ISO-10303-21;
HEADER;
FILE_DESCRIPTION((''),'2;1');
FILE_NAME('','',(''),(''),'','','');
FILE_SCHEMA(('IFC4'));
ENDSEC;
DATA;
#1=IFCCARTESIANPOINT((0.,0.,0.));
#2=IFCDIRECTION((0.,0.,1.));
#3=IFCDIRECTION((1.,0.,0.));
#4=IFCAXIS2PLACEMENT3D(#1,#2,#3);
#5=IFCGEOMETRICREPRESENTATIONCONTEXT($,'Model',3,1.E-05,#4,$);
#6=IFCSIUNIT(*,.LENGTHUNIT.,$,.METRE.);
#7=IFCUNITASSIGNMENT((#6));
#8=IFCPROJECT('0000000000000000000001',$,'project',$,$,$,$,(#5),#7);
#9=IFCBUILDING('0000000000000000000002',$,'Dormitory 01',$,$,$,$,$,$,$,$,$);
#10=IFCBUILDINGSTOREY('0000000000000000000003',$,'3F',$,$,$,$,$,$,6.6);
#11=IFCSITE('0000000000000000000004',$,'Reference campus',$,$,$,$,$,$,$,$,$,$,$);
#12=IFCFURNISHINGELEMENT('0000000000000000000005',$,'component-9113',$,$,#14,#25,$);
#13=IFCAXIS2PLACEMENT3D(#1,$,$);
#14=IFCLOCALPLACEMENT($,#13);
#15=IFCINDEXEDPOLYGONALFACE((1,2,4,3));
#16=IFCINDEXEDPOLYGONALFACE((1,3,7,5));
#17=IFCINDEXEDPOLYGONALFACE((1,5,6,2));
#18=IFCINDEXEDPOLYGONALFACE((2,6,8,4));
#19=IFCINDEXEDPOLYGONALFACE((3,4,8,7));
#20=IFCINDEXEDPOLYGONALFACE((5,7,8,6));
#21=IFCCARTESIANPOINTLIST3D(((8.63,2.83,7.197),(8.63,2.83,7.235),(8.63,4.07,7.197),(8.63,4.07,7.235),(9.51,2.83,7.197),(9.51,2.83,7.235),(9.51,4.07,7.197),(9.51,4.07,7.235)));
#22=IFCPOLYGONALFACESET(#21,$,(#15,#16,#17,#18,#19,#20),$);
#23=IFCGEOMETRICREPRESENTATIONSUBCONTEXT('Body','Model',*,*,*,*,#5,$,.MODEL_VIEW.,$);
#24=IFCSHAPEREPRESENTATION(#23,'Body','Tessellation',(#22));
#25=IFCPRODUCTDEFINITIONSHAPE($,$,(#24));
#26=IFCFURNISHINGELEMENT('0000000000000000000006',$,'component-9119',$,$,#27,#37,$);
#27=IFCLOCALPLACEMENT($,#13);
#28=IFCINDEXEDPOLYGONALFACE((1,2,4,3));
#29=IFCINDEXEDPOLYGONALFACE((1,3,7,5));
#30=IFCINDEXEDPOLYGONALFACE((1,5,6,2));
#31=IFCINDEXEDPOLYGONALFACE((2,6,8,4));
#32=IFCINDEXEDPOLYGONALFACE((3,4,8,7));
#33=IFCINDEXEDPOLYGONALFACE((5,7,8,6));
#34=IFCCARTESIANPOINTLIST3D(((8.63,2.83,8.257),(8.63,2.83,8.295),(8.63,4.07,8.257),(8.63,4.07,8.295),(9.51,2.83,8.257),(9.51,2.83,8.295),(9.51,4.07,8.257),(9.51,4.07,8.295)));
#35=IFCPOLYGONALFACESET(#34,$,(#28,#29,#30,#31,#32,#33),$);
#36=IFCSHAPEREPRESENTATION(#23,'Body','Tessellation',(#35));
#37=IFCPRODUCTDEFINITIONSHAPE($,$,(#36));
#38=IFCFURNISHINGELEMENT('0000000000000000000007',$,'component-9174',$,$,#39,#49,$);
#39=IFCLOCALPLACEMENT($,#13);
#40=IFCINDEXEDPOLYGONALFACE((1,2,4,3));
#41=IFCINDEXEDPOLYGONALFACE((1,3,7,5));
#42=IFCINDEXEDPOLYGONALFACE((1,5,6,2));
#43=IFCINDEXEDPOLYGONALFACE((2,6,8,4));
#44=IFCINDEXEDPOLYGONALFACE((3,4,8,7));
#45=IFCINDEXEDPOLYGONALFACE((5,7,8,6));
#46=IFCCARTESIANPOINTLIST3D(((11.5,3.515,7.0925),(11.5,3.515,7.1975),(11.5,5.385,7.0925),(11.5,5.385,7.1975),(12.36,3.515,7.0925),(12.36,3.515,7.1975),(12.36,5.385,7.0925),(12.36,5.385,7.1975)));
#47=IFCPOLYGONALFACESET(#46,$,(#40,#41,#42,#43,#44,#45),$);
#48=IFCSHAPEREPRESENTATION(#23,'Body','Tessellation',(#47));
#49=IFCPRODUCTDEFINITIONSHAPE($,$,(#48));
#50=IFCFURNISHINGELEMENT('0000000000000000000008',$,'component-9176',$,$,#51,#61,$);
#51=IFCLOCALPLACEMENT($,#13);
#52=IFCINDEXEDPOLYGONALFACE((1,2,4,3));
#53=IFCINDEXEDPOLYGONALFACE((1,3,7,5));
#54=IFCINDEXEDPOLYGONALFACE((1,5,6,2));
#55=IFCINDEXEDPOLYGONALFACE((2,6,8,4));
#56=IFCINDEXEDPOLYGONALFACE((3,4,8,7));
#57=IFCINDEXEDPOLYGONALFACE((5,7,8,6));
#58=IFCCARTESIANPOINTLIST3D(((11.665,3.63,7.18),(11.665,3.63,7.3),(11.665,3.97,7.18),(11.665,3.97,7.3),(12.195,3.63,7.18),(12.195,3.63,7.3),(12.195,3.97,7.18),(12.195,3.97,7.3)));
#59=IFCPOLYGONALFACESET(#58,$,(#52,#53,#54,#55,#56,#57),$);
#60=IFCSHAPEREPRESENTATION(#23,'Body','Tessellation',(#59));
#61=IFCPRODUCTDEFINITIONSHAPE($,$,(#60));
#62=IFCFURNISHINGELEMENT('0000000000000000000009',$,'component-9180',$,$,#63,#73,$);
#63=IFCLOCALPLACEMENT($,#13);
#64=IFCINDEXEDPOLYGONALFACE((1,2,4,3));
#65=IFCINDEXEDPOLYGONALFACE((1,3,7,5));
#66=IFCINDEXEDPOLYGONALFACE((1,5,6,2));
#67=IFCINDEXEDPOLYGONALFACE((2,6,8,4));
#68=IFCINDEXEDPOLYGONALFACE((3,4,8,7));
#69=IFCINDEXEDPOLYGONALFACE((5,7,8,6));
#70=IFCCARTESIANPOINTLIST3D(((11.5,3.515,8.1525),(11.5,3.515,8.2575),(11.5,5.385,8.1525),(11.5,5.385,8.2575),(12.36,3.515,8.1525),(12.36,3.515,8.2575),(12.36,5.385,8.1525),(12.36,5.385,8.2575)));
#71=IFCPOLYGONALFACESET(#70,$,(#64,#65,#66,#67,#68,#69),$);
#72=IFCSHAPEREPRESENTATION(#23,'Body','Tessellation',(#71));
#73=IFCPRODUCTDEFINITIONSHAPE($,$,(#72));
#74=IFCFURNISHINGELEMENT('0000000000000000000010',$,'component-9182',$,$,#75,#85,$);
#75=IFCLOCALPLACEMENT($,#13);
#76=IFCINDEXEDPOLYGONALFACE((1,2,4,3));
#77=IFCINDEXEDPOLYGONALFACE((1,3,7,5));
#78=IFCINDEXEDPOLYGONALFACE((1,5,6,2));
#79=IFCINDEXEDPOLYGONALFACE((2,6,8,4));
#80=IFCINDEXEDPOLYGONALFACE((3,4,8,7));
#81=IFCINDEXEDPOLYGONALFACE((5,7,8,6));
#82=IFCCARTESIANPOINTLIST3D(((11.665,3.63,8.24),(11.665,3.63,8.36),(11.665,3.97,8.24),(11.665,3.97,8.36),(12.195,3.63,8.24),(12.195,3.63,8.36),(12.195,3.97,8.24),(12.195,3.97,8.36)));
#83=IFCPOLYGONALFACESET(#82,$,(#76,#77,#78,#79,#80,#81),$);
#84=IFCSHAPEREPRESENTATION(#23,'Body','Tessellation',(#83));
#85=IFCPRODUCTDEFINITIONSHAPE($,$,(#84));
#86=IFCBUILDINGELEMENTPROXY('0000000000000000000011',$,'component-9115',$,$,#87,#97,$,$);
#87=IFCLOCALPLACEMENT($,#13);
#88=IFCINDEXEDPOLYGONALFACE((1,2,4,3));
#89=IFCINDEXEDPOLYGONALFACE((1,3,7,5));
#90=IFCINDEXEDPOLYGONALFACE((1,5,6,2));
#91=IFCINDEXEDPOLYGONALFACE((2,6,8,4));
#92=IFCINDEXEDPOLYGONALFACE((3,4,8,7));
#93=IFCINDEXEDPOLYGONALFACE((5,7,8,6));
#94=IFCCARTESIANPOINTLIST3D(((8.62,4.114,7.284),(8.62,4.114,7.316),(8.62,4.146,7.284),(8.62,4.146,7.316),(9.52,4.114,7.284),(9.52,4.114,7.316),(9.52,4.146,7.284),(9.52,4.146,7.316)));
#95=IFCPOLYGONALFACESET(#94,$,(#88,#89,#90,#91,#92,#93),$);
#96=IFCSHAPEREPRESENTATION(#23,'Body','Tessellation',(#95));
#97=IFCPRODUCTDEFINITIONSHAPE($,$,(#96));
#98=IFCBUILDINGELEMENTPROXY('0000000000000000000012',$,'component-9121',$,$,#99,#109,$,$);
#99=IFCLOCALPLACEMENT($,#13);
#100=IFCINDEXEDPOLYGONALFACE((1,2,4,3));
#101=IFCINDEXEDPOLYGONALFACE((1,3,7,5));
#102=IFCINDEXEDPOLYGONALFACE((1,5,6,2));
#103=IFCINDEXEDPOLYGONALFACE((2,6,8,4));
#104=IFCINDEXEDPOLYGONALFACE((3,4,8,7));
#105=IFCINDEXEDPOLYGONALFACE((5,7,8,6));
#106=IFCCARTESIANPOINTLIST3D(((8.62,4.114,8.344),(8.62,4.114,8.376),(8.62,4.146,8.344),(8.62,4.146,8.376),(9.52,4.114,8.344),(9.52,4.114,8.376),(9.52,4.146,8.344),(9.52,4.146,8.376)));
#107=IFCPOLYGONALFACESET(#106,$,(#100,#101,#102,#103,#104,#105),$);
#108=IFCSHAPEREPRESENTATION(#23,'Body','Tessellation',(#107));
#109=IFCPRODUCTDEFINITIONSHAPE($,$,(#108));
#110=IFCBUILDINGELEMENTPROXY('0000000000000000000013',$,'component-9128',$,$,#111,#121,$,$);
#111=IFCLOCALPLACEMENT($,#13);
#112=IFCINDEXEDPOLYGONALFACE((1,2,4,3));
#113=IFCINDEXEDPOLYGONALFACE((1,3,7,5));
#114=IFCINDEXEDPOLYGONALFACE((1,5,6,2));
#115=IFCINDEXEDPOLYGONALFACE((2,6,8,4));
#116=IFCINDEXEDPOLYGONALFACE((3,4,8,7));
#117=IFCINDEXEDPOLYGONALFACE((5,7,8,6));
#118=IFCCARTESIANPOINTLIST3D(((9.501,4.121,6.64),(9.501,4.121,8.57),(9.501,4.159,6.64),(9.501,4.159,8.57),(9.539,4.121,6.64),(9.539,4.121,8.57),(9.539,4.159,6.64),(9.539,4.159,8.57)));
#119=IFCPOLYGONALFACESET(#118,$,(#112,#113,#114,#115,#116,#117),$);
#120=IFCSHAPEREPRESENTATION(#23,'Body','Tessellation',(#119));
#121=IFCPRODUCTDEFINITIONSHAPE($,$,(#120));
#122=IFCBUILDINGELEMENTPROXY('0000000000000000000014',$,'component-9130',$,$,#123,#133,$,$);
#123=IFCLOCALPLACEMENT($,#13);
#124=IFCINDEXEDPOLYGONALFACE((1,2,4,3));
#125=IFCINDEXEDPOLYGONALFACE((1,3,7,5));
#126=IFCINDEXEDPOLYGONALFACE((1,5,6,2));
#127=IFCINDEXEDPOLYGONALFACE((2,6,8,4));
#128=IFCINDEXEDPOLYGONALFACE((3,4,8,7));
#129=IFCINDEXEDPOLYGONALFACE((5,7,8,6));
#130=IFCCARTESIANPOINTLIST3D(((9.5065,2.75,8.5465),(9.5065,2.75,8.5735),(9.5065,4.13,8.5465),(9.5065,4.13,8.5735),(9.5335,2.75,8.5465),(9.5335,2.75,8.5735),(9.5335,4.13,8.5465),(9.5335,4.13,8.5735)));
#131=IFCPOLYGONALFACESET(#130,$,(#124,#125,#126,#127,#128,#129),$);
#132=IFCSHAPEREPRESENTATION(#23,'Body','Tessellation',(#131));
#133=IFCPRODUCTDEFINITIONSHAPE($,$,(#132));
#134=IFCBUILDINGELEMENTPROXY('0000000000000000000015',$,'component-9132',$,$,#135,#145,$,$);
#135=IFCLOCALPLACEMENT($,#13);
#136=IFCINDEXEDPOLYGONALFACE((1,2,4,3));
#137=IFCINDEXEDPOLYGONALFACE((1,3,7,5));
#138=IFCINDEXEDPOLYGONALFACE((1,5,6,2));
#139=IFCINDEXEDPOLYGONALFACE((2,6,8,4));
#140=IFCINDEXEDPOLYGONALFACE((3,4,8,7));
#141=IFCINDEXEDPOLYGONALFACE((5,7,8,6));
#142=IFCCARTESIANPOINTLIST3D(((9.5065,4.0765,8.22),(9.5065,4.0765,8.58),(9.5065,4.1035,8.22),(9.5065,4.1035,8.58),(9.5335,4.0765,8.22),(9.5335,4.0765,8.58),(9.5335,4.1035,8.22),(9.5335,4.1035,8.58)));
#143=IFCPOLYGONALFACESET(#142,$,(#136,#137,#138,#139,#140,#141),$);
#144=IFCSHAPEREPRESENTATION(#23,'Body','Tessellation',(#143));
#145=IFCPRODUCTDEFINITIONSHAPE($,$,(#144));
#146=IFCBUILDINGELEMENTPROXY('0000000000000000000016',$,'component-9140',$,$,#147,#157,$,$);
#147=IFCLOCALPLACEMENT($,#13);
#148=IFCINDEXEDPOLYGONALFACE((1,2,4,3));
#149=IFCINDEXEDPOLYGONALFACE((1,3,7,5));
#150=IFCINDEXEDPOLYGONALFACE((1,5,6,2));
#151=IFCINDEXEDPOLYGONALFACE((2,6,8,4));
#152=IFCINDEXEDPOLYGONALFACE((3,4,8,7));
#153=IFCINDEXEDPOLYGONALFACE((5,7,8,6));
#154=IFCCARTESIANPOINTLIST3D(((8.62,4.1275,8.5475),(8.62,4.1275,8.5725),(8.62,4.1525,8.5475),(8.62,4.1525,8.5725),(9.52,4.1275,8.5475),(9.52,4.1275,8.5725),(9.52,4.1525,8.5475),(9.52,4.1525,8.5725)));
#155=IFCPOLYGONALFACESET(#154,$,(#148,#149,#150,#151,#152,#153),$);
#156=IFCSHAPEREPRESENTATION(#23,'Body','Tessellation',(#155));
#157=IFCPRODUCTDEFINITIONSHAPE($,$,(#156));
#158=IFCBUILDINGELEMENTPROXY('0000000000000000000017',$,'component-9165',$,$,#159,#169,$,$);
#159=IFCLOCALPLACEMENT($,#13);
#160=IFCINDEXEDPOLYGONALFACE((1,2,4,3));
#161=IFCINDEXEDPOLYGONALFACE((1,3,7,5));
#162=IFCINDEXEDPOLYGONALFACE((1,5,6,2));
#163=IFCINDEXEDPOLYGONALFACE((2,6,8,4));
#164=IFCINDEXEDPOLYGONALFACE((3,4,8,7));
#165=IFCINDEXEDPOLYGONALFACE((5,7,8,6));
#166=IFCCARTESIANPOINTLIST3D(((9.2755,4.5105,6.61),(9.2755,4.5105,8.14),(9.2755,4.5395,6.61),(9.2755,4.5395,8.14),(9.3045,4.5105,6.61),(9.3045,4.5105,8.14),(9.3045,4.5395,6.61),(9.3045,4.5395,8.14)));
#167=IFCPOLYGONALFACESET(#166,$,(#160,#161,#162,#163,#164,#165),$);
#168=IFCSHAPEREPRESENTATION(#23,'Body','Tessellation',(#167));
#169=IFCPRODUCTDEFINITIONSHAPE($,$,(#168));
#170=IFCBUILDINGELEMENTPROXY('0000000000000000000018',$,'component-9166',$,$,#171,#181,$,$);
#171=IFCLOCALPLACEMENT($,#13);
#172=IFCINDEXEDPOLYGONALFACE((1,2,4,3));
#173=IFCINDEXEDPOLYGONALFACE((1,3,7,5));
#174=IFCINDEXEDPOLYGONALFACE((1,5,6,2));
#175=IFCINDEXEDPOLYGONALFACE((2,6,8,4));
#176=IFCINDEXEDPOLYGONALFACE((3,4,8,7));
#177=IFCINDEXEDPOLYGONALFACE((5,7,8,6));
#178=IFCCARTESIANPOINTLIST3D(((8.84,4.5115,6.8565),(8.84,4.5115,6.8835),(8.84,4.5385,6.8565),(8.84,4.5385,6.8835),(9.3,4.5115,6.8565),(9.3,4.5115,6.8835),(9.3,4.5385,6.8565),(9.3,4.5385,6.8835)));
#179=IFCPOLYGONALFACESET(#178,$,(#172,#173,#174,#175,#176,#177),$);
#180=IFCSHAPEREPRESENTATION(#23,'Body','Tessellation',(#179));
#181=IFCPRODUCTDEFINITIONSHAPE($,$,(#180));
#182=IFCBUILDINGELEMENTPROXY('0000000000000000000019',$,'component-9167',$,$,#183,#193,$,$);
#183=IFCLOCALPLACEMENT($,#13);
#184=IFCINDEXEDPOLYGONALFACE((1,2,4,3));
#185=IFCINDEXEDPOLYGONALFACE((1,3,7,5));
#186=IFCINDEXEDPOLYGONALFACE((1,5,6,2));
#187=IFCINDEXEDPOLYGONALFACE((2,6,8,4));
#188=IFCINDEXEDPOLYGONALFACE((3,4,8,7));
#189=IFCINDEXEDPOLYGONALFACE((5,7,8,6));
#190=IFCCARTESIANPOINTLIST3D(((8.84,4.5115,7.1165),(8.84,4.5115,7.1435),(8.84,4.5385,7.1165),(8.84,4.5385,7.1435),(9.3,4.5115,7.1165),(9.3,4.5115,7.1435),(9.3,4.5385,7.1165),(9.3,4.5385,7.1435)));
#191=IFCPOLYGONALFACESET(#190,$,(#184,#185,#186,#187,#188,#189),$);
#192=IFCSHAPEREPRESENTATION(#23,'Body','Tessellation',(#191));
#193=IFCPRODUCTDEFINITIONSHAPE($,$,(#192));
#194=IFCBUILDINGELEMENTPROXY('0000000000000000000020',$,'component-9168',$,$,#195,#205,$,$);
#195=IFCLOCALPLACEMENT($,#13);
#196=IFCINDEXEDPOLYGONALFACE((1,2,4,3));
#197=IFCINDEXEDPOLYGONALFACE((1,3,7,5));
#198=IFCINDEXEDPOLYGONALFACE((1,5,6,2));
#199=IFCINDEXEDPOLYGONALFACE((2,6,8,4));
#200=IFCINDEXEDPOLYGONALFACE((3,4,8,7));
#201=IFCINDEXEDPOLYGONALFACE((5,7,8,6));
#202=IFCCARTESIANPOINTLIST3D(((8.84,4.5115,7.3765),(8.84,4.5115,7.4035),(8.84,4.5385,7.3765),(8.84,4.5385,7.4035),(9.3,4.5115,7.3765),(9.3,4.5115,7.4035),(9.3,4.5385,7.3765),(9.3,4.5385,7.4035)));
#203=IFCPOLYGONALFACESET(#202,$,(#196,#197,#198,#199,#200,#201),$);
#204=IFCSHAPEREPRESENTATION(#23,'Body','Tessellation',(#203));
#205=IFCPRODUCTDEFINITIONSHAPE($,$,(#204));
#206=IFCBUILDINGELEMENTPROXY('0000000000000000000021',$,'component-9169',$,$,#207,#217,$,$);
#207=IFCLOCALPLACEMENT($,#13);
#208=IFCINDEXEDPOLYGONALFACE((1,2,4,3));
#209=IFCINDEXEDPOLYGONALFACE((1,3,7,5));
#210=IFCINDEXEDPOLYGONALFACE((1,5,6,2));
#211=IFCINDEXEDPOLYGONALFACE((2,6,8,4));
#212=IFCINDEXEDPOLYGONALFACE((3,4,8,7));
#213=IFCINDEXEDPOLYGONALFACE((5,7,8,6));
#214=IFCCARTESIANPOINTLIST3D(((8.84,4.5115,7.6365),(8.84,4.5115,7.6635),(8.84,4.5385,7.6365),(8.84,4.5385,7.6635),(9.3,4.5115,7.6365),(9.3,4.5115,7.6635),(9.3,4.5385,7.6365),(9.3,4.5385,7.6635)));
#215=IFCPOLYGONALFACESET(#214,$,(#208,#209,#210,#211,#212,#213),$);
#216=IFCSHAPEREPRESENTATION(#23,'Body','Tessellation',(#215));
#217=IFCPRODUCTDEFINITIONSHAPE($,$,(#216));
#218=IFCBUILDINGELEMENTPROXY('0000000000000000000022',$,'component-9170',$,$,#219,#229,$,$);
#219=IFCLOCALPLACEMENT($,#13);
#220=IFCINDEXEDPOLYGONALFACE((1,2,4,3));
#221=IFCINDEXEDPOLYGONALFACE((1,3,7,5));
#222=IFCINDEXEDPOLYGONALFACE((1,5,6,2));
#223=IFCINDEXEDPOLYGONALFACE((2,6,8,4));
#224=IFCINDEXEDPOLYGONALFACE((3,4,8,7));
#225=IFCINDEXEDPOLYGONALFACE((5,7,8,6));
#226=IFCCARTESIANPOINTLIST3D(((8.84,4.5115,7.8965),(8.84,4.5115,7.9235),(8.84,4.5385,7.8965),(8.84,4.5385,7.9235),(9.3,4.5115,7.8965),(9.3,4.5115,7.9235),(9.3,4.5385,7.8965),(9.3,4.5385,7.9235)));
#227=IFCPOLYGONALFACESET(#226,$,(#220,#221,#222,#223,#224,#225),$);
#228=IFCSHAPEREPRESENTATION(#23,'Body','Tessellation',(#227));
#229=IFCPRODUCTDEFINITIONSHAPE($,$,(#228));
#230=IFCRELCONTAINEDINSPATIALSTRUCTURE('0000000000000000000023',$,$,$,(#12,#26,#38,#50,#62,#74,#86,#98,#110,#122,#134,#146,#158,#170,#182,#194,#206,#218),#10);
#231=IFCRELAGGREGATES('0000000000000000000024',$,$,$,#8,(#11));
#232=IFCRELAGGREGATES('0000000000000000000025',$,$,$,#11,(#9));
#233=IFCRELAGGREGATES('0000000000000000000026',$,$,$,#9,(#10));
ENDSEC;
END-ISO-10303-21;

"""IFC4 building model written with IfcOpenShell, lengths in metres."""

from ifc_helpers import new_model, si_unit, frame, origin, origin_with_axes, origin_2d, place, context, subcontext, project, spatial, rectangle, extrude, element, save


model = new_model("IFC4")

# Units and contexts
model_context = context("Model", 3, precision=1e-05, world=origin_with_axes())
body_context = subcontext(model_context, "Body", "Model", "MODEL_VIEW")
ifc_project = project(units=[si_unit("LENGTHUNIT", "METRE")], contexts=[model_context])

# Site, building, storey
site = spatial("IfcSite", under=ifc_project, Name="Reference campus")
building = spatial("IfcBuilding", under=site, Name="Dormitory 01")
storey = spatial("IfcBuildingStorey", under=building, Name="3F", Elevation=6.6)

# Furnishing elements
for number, where, z_axis, x_axis, name in (
    (1, (9.07, 3.45, 7.197), (0.0, 0.0, 1.0), (1.0, 0.0, 0.0), "component-9113"),
    (2, (9.07, 3.45, 8.257), (0.0, 0.0, 1.0), (1.0, 0.0, 0.0), "component-9119"),
):
    element("IfcFurnishingElement", number, at=place(None, frame(where, z_axis=z_axis, x_axis=x_axis)), inside=storey, Name=name, context=body_context, shape_type="SweptSolid", body=[
        extrude(rectangle(XDim=0.88, YDim=1.24, at=origin_2d()), origin(), (0.0, 0.0, 1.0), 0.038),
    ])
furnishing_1_placement = place(None, frame((11.93, 4.45, 7.0925), z_axis=(0.0, 0.0, 1.0), x_axis=(1.0, 0.0, 0.0)))
element("IfcFurnishingElement", 3, at=furnishing_1_placement, inside=storey, Name="component-9174", context=body_context, shape_type="SweptSolid", body=[
    extrude(rectangle(XDim=0.86, YDim=1.87, at=origin_2d()), origin(), (0.0, 0.0, 1.0), 0.105),
])
furnishing_2_placement = place(None, frame((11.93, 3.8, 7.18), z_axis=(0.0, 0.0, 1.0), x_axis=(1.0, 0.0, 0.0)))
element("IfcFurnishingElement", 4, at=furnishing_2_placement, inside=storey, Name="component-9176", context=body_context, shape_type="SweptSolid", body=[
    extrude(rectangle(XDim=0.53, YDim=0.34, at=origin_2d()), origin(), (0.0, 0.0, 1.0), 0.12),
])
furnishing_3_placement = place(None, frame((11.93, 4.45, 8.1525), z_axis=(0.0, 0.0, 1.0), x_axis=(1.0, 0.0, 0.0)))
element("IfcFurnishingElement", 5, at=furnishing_3_placement, inside=storey, Name="component-9180", context=body_context, shape_type="SweptSolid", body=[
    extrude(rectangle(XDim=0.86, YDim=1.87, at=origin_2d()), origin(), (0.0, 0.0, 1.0), 0.105),
])
furnishing_4_placement = place(None, frame((11.93, 3.8, 8.24), z_axis=(0.0, 0.0, 1.0), x_axis=(1.0, 0.0, 0.0)))
element("IfcFurnishingElement", 6, at=furnishing_4_placement, inside=storey, Name="component-9182", context=body_context, shape_type="SweptSolid", body=[
    extrude(rectangle(XDim=0.53, YDim=0.34, at=origin_2d()), origin(), (0.0, 0.0, 1.0), 0.12),
])

# Building element proxies
for number, where, z_axis, x_axis, name in (
    (7, (9.07, 4.13, 7.284), (0.0, 0.0, 1.0), (1.0, 0.0, 0.0), "component-9115"),
    (8, (9.07, 4.13, 8.344), (0.0, 0.0, 1.0), (1.0, 0.0, 0.0), "component-9121"),
):
    element("IfcBuildingElementProxy", number, at=place(None, frame(where, z_axis=z_axis, x_axis=x_axis)), inside=storey, Name=name, context=body_context, shape_type="SweptSolid", body=[
        extrude(rectangle(XDim=0.9, YDim=0.032, at=origin_2d()), origin(), (0.0, 0.0, 1.0), 0.032),
    ])
proxy_1_placement = place(None, frame((9.52, 4.14, 6.64), z_axis=(0.0, 0.0, 1.0), x_axis=(1.0, 0.0, 0.0)))
element("IfcBuildingElementProxy", 9, at=proxy_1_placement, inside=storey, Name="component-9128", context=body_context, shape_type="SweptSolid", body=[
    extrude(rectangle(XDim=0.038, YDim=0.038, at=origin_2d()), origin(), (0.0, 0.0, 1.0), 1.93),
])
proxy_2_placement = place(None, frame((9.52, 3.44, 8.5465), z_axis=(0.0, 0.0, 1.0), x_axis=(1.0, 0.0, 0.0)))
element("IfcBuildingElementProxy", 10, at=proxy_2_placement, inside=storey, Name="component-9130", context=body_context, shape_type="SweptSolid", body=[
    extrude(rectangle(XDim=0.027, YDim=1.38, at=origin_2d()), origin(), (0.0, 0.0, 1.0), 0.027),
])
proxy_3_placement = place(None, frame((9.52, 4.09, 8.22), z_axis=(0.0, 0.0, 1.0), x_axis=(1.0, 0.0, 0.0)))
element("IfcBuildingElementProxy", 11, at=proxy_3_placement, inside=storey, Name="component-9132", context=body_context, shape_type="SweptSolid", body=[
    extrude(rectangle(XDim=0.027, YDim=0.027, at=origin_2d()), origin(), (0.0, 0.0, 1.0), 0.36),
])
proxy_4_placement = place(None, frame((9.07, 4.14, 8.5475), z_axis=(0.0, 0.0, 1.0), x_axis=(1.0, 0.0, 0.0)))
element("IfcBuildingElementProxy", 12, at=proxy_4_placement, inside=storey, Name="component-9140", context=body_context, shape_type="SweptSolid", body=[
    extrude(rectangle(XDim=0.9, YDim=0.025, at=origin_2d()), origin(), (0.0, 0.0, 1.0), 0.025),
])
proxy_5_placement = place(None, frame((9.29, 4.525, 6.61), z_axis=(0.0, 0.0, 1.0), x_axis=(1.0, 0.0, 0.0)))
element("IfcBuildingElementProxy", 13, at=proxy_5_placement, inside=storey, Name="component-9165", context=body_context, shape_type="SweptSolid", body=[
    extrude(rectangle(XDim=0.029, YDim=0.029, at=origin_2d()), origin(), (0.0, 0.0, 1.0), 1.53),
])
for number, where, z_axis, x_axis, name in (
    (14, (9.07, 4.525, 6.8565), (0.0, 0.0, 1.0), (1.0, 0.0, 0.0), "component-9166"),
    (15, (9.07, 4.525, 7.1165), (0.0, 0.0, 1.0), (1.0, 0.0, 0.0), "component-9167"),
    (16, (9.07, 4.525, 7.3765), (0.0, 0.0, 1.0), (1.0, 0.0, 0.0), "component-9168"),
    (17, (9.07, 4.525, 7.6365), (0.0, 0.0, 1.0), (1.0, 0.0, 0.0), "component-9169"),
    (18, (9.07, 4.525, 7.8965), (0.0, 0.0, 1.0), (1.0, 0.0, 0.0), "component-9170"),
):
    element("IfcBuildingElementProxy", number, at=place(None, frame(where, z_axis=z_axis, x_axis=x_axis)), inside=storey, Name=name, context=body_context, shape_type="SweptSolid", body=[
        extrude(rectangle(XDim=0.46, YDim=0.027, at=origin_2d()), origin(), (0.0, 0.0, 1.0), 0.027),
    ])

save(model, "model.ifc")
